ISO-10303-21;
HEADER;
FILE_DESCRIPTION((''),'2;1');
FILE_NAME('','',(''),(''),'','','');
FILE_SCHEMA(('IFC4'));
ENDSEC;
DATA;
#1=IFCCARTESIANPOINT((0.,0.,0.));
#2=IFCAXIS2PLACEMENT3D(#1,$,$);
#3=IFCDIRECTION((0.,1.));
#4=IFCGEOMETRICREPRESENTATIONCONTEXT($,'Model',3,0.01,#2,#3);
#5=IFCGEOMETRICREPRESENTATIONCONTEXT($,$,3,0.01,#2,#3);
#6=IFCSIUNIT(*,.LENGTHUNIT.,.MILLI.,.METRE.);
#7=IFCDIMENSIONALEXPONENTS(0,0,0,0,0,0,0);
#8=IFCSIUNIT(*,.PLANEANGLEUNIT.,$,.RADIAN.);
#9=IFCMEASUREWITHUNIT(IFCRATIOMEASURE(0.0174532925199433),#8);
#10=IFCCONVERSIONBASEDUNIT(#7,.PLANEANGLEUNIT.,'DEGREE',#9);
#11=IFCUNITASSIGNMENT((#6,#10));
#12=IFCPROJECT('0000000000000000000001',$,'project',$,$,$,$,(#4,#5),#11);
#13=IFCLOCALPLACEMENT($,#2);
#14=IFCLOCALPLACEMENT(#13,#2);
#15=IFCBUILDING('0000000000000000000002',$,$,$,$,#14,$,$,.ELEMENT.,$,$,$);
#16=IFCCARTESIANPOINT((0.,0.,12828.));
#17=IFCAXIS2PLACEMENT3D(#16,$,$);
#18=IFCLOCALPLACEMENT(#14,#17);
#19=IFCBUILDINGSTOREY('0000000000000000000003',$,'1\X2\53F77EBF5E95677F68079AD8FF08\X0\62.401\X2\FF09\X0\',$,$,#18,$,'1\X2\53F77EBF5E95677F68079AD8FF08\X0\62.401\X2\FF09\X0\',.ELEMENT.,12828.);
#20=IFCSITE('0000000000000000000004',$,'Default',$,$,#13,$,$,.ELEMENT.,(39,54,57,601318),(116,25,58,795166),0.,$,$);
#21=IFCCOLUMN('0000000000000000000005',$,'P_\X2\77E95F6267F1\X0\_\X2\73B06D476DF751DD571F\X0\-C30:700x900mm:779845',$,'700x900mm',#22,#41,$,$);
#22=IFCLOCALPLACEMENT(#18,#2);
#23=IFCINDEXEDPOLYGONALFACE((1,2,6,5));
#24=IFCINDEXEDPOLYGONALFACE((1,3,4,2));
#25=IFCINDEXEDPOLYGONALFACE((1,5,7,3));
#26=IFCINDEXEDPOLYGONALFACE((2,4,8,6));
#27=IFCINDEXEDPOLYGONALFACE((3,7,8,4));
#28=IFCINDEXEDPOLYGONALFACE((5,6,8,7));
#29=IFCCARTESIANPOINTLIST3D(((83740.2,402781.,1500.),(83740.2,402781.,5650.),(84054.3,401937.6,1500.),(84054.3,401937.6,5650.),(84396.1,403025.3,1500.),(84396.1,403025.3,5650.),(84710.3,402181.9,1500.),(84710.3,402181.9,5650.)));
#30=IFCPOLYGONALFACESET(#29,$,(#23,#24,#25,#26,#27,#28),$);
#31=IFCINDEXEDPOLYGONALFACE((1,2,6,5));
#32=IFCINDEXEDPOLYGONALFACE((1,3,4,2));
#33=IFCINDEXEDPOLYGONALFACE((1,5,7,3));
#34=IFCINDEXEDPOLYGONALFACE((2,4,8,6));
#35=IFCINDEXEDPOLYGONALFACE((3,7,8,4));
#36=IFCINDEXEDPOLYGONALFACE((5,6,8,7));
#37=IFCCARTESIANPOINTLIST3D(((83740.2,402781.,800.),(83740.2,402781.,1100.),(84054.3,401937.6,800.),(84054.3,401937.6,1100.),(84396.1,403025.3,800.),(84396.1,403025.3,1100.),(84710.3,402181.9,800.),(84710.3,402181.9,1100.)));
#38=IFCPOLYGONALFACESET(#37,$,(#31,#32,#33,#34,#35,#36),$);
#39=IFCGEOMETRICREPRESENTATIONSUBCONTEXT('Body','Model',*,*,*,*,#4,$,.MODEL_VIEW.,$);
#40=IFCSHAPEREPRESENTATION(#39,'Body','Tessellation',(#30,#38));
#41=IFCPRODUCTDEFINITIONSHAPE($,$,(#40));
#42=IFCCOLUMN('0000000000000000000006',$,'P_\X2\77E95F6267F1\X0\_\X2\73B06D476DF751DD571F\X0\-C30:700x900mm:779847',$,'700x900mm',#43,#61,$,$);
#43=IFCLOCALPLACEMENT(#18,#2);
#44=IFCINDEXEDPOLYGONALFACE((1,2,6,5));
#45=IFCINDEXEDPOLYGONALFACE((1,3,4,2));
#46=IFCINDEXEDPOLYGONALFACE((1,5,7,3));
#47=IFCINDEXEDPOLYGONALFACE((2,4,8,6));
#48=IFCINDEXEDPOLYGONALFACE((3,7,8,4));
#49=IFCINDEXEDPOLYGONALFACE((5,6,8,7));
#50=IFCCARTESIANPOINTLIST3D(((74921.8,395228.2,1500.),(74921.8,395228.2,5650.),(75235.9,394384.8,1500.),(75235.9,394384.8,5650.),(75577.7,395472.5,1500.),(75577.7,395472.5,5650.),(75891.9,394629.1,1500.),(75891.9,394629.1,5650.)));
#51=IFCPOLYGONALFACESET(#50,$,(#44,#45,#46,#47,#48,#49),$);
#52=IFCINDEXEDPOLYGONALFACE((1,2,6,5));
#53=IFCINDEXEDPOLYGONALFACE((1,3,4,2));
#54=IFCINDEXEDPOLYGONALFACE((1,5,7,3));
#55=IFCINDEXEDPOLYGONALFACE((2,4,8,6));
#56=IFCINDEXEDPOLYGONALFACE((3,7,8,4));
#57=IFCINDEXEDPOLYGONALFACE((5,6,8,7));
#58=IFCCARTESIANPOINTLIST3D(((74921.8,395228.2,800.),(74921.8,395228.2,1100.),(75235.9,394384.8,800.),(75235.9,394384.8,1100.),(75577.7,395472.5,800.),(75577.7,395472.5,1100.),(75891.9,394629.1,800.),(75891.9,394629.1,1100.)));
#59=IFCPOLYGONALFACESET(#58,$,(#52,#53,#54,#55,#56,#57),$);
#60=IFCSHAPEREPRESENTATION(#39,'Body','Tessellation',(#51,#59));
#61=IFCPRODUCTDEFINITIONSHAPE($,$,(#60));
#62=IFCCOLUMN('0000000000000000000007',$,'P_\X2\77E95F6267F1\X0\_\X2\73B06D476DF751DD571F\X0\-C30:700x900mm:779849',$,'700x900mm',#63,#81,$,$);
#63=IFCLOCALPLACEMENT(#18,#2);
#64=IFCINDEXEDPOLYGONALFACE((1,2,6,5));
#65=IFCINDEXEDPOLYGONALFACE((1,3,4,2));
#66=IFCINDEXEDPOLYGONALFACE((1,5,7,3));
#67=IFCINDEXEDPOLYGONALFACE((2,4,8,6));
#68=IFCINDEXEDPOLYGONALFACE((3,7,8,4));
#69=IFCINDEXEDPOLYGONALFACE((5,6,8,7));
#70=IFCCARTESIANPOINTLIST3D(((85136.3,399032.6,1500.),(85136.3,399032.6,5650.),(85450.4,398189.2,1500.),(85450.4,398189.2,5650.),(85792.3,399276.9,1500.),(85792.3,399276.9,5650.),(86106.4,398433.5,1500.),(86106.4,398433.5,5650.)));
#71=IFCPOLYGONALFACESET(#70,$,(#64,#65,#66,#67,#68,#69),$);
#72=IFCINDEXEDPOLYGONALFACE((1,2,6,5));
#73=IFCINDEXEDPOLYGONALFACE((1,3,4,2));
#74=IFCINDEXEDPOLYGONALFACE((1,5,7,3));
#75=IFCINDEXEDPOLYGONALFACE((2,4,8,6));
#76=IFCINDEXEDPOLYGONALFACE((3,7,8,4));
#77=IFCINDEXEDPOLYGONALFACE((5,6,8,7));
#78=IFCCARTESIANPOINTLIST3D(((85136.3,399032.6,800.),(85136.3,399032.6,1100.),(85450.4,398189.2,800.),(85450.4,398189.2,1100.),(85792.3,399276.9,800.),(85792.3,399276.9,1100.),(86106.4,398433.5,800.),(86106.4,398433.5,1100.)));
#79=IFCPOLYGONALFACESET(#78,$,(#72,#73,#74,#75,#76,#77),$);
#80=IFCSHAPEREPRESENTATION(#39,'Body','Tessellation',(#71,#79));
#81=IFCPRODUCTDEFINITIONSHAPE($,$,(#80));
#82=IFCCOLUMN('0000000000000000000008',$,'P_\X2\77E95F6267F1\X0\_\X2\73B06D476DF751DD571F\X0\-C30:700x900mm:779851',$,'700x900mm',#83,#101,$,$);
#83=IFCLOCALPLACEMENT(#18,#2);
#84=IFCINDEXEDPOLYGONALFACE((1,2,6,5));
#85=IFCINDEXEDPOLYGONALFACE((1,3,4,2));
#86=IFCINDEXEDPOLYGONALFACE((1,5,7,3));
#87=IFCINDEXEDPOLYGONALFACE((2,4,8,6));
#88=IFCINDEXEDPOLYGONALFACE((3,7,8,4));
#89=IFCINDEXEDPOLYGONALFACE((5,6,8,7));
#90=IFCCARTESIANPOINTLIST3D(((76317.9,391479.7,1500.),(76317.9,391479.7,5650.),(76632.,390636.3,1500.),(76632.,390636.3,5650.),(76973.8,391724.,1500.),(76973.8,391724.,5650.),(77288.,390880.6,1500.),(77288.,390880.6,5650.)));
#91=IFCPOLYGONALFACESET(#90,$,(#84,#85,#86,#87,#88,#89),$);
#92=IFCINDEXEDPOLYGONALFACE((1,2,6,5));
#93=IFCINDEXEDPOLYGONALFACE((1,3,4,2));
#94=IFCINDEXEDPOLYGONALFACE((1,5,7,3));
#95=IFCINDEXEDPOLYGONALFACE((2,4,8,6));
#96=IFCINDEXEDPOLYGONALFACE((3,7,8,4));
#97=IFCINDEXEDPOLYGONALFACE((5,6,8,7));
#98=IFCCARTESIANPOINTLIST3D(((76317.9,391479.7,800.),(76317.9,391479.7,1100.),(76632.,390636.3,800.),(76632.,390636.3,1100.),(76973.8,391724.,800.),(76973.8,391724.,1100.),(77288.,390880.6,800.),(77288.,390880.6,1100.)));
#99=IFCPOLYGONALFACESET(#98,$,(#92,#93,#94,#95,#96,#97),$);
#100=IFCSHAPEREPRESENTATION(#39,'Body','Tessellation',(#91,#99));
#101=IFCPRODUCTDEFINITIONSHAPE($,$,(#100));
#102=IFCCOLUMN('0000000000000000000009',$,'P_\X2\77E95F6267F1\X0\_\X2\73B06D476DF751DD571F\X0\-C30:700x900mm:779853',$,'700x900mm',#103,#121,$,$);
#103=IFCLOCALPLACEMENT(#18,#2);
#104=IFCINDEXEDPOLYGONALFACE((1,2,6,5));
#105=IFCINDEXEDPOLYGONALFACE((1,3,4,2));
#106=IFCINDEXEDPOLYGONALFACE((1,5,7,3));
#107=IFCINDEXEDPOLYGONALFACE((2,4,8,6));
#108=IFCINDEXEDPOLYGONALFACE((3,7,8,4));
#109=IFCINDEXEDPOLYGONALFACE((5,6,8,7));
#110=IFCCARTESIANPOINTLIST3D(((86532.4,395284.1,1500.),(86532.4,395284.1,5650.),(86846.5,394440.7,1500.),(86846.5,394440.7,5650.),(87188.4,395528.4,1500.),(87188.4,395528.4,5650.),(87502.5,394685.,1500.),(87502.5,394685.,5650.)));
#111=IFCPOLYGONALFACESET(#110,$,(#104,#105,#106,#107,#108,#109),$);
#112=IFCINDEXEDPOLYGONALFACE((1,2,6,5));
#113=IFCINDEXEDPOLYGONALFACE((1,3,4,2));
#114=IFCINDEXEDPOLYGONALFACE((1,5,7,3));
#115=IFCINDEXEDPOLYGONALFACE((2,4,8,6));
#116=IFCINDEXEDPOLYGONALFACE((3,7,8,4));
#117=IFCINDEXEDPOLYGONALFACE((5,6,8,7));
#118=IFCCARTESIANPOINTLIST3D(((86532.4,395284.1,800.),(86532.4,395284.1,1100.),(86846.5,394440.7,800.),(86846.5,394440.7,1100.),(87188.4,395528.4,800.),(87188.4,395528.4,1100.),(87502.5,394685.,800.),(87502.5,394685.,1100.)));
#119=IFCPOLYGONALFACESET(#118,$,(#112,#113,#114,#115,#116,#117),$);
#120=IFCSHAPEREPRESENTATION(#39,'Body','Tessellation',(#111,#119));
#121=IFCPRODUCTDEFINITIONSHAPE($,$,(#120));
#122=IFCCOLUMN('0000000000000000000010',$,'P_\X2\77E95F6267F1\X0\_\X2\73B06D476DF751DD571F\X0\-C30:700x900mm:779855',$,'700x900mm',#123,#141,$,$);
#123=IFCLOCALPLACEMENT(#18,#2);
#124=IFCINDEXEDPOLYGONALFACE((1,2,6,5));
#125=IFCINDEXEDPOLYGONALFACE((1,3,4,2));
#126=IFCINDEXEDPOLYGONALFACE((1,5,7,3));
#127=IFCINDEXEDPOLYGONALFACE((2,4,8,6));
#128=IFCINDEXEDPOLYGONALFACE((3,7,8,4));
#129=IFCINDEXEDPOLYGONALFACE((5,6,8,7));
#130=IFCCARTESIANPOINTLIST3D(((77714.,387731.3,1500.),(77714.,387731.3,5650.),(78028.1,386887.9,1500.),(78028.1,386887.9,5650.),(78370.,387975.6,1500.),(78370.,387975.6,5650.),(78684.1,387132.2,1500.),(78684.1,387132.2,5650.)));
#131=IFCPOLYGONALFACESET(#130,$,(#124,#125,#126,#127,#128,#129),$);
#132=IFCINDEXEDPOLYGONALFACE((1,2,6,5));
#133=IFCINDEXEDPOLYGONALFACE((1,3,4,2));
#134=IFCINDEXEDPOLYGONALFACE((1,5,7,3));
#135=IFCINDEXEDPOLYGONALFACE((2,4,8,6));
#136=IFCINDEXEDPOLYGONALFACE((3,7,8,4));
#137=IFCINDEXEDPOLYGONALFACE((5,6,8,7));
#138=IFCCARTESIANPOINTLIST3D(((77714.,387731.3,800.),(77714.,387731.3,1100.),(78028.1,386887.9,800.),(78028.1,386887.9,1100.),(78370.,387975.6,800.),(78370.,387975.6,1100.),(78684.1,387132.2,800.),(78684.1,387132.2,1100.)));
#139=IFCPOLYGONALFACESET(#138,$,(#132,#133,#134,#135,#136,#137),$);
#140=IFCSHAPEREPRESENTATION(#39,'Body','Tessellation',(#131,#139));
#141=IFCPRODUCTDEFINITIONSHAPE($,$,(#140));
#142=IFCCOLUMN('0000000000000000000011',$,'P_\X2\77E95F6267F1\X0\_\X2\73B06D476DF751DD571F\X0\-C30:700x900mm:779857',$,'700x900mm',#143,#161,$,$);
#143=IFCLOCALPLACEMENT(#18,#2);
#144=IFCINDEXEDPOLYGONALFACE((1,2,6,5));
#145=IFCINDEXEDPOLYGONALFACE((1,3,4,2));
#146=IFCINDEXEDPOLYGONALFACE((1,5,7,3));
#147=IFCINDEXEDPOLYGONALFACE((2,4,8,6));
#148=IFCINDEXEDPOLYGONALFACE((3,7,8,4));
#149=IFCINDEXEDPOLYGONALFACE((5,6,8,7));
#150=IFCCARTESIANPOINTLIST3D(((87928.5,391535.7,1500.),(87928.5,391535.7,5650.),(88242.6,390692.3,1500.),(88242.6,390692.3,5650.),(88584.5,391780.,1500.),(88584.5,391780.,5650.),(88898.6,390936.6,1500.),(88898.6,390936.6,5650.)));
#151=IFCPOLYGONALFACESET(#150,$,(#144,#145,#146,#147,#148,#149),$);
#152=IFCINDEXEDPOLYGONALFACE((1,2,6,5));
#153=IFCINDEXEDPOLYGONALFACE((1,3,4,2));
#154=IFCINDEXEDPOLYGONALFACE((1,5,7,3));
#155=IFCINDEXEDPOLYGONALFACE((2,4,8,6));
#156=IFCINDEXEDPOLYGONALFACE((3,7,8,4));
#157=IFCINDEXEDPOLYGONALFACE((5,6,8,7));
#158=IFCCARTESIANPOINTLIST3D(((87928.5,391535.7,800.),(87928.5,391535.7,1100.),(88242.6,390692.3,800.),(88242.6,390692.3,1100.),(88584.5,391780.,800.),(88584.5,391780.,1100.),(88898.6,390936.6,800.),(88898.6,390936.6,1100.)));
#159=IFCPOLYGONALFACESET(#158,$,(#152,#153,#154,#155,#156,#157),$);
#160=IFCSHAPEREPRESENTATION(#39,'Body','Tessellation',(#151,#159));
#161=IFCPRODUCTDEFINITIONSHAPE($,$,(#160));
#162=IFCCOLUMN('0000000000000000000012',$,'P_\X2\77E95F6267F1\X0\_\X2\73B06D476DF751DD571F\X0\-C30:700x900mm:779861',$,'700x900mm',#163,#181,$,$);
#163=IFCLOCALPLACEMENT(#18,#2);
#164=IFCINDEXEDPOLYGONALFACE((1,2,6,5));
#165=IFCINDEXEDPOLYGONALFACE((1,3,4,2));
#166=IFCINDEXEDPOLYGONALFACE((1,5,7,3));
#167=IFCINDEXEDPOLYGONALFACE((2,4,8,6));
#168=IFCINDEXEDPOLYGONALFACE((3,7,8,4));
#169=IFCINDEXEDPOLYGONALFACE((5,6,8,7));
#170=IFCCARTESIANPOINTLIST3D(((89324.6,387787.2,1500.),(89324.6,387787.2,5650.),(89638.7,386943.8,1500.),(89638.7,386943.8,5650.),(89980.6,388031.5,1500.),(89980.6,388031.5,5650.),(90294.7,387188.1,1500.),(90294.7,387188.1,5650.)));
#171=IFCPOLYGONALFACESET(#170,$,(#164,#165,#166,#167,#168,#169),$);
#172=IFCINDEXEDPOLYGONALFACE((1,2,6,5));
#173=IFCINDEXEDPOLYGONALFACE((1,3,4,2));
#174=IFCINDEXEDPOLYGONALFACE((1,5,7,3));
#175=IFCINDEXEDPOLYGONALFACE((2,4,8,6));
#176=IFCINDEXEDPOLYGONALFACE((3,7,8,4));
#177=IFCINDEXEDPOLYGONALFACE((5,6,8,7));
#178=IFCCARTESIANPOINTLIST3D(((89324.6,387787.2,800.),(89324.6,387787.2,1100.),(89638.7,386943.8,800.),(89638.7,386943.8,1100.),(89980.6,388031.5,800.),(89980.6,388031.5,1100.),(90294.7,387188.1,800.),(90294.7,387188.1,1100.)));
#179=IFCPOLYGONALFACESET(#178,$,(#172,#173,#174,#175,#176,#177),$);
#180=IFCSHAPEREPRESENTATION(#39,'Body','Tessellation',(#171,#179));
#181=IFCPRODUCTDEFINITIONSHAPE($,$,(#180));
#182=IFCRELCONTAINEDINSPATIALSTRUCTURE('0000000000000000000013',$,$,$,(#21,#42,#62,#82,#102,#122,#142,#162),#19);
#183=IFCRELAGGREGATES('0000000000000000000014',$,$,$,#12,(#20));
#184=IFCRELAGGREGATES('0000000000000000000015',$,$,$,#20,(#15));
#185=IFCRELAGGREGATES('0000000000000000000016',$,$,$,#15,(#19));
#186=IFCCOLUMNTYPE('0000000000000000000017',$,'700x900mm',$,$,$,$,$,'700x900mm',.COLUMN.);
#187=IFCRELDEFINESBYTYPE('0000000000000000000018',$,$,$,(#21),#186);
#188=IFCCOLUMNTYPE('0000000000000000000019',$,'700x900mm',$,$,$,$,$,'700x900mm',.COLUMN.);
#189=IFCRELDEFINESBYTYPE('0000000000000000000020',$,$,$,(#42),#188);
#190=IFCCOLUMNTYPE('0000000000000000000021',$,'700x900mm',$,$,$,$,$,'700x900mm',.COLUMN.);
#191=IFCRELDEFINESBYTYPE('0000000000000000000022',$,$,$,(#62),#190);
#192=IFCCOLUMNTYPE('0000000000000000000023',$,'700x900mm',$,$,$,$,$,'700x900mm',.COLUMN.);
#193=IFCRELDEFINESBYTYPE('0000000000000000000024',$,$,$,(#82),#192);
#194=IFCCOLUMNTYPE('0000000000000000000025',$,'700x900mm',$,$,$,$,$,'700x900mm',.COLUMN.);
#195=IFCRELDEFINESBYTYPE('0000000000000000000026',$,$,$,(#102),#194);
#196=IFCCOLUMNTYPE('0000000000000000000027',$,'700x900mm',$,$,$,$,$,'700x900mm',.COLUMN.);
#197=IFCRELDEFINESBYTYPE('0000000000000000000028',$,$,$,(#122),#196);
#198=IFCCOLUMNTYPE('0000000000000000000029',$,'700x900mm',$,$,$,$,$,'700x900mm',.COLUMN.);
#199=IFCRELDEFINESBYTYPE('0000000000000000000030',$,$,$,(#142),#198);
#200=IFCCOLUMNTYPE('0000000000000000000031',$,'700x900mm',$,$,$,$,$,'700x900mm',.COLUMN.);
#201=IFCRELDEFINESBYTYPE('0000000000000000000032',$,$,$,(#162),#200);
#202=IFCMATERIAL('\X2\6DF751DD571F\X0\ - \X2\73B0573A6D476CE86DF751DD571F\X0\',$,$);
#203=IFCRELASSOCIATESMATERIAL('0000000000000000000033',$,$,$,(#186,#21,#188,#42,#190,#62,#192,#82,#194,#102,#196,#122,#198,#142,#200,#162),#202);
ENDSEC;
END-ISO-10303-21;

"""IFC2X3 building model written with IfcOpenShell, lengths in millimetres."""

from ifc_helpers import new_model, entity, si_unit, converted_unit, direction, frame, frame_2d, origin, origin_2d_with_axis, place, context, subcontext, project, spatial, rectangle, extrude, source, transform, mapped, material, type_object, type_shapes, element, save


model = new_model("IFC2X3")

# Units and contexts
model_context = context("Model", 3, precision=0.01, world=origin(), true_north=direction((0.0, 1.0)))
context_of_model = context(None, 3, precision=0.01, world=origin(), true_north=direction((0.0, 1.0)))
body_context = subcontext(model_context, "Body", "Model", "MODEL_VIEW")
ifc_project = project(units=[si_unit("LENGTHUNIT", "METRE", prefix="MILLI"), converted_unit("PLANEANGLEUNIT", "DEGREE", entity("IfcRatioMeasure", 0.0174532925199433), si_unit("PLANEANGLEUNIT", "RADIAN"), dimensions=[0, 0, 0, 0, 0, 0, 0])], contexts=[model_context, context_of_model])

# Site, building, storey
site_placement = place(None, origin())
site = spatial("IfcSite", under=ifc_project, at=site_placement, Name="Default", CompositionType="ELEMENT", RefLatitude=(39, 54, 57, 601318), RefLongitude=(116, 25, 58, 795166), RefElevation=0.0)
building_placement = place(site_placement, origin())
building = spatial("IfcBuilding", under=site, at=building_placement, CompositionType="ELEMENT")
storey_placement = place(building_placement, frame((0.0, 0.0, 12828.0)))
storey = spatial("IfcBuildingStorey", under=building, at=storey_placement, Name="1号线底板标高（62.401）", LongName="1号线底板标高（62.401）", CompositionType="ELEMENT", Elevation=12828.0)

# Columns
ifc_material_1 = material(Name="混凝土 - 现场浇注混凝土")
column_type_1 = type_object("IfcColumnType", Name="700x900mm", ElementType="700x900mm", PredefinedType="COLUMN", material=ifc_material_1)
shared_shape_1 = source(origin(), body_context, "Body", "SweptSolid", [
    extrude(rectangle(XDim=700.0, YDim=900.0, at=frame_2d((0.0, 0.0), x_axis=(1.0, 0.0))), frame((485.1, 543.9, 700.0), z_axis=(0.0, 0.0, 1.0), x_axis=(-0.937112, -0.349028, 0.0)), (0.0, 0.0, 1.0), 4150.0),
    extrude(rectangle(XDim=700.0, YDim=900.0, at=frame_2d((0.0, 0.0), x_axis=(1.0, 0.0))), frame((485.1, 543.9, 0.0), z_axis=(0.0, 0.0, 1.0), x_axis=(-0.937112, -0.349028, 0.0)), (0.0, 0.0, 1.0), 300.0),
])
type_shapes(column_type_1, [shared_shape_1])
column_1_placement = place(storey_placement, frame((83740.2, 401937.6, 800.0)))
element("IfcColumn", 1, at=column_1_placement, inside=storey, type_object=column_type_1, material=ifc_material_1, Name="P_矩形柱_现浇混凝土-C30:700x900mm:779845", ObjectType="700x900mm", context=body_context, shape_type="MappedRepresentation", body=[
    mapped(shared_shape_1, transform((0.0, 0.0, 0.0), scale=1.0)),
])
column_type_2 = type_object("IfcColumnType", Name="700x900mm", ElementType="700x900mm", PredefinedType="COLUMN", material=ifc_material_1)
shared_shape_2 = source(origin(), body_context, "Body", "SweptSolid", [
    extrude(rectangle(XDim=700.0, YDim=900.0, at=frame_2d((0.0, 0.0), x_axis=(1.0, 0.0))), frame((485.1, 543.9, 700.0), z_axis=(0.0, 0.0, 1.0), x_axis=(-0.937112, -0.349028, 0.0)), (0.0, 0.0, 1.0), 4150.0),
    extrude(rectangle(XDim=700.0, YDim=900.0, at=frame_2d((0.0, 0.0), x_axis=(1.0, 0.0))), frame((485.1, 543.9, 0.0), z_axis=(0.0, 0.0, 1.0), x_axis=(-0.937112, -0.349028, 0.0)), (0.0, 0.0, 1.0), 300.0),
])
type_shapes(column_type_2, [shared_shape_2])
column_2_placement = place(storey_placement, frame((74921.8, 394384.8, 800.0)))
element("IfcColumn", 2, at=column_2_placement, inside=storey, type_object=column_type_2, material=ifc_material_1, Name="P_矩形柱_现浇混凝土-C30:700x900mm:779847", ObjectType="700x900mm", context=body_context, shape_type="MappedRepresentation", body=[
    mapped(shared_shape_2, transform((0.0, 0.0, 0.0), scale=1.0)),
])
column_type_3 = type_object("IfcColumnType", Name="700x900mm", ElementType="700x900mm", PredefinedType="COLUMN", material=ifc_material_1)
shared_shape_3 = source(origin(), body_context, "Body", "SweptSolid", [
    extrude(rectangle(XDim=700.0, YDim=900.0, at=origin_2d_with_axis()), frame((485.1, 543.9, 700.0), z_axis=(0.0, 0.0, 1.0), x_axis=(-0.937112, -0.349028, 0.0)), (0.0, 0.0, 1.0), 4150.0),
    extrude(rectangle(XDim=700.0, YDim=900.0, at=origin_2d_with_axis()), frame((485.1, 543.9, 0.0), z_axis=(0.0, 0.0, 1.0), x_axis=(-0.937112, -0.349028, 0.0)), (0.0, 0.0, 1.0), 300.0),
])
type_shapes(column_type_3, [shared_shape_3])
column_3_placement = place(storey_placement, frame((85136.3, 398189.2, 800.0)))
element("IfcColumn", 3, at=column_3_placement, inside=storey, type_object=column_type_3, material=ifc_material_1, Name="P_矩形柱_现浇混凝土-C30:700x900mm:779849", ObjectType="700x900mm", context=body_context, shape_type="MappedRepresentation", body=[
    mapped(shared_shape_3, transform((0.0, 0.0, 0.0), scale=1.0)),
])
column_type_4 = type_object("IfcColumnType", Name="700x900mm", ElementType="700x900mm", PredefinedType="COLUMN", material=ifc_material_1)
shared_shape_4 = source(origin(), body_context, "Body", "SweptSolid", [
    extrude(rectangle(XDim=700.0, YDim=900.0, at=frame_2d((0.0, 0.0), x_axis=(1.0, 0.0))), frame((485.1, 543.9, 700.0), z_axis=(0.0, 0.0, 1.0), x_axis=(-0.937112, -0.349028, 0.0)), (0.0, 0.0, 1.0), 4150.0),
    extrude(rectangle(XDim=700.0, YDim=900.0, at=frame_2d((0.0, 0.0), x_axis=(1.0, 0.0))), frame((485.1, 543.9, 0.0), z_axis=(0.0, 0.0, 1.0), x_axis=(-0.937112, -0.349028, 0.0)), (0.0, 0.0, 1.0), 300.0),
])
type_shapes(column_type_4, [shared_shape_4])
column_4_placement = place(storey_placement, frame((76317.9, 390636.3, 800.0)))
element("IfcColumn", 4, at=column_4_placement, inside=storey, type_object=column_type_4, material=ifc_material_1, Name="P_矩形柱_现浇混凝土-C30:700x900mm:779851", ObjectType="700x900mm", context=body_context, shape_type="MappedRepresentation", body=[
    mapped(shared_shape_4, transform((0.0, 0.0, 0.0), scale=1.0)),
])
column_type_5 = type_object("IfcColumnType", Name="700x900mm", ElementType="700x900mm", PredefinedType="COLUMN", material=ifc_material_1)
shared_shape_5 = source(origin(), body_context, "Body", "SweptSolid", [
    extrude(rectangle(XDim=700.0, YDim=900.0, at=frame_2d((0.0, 0.0), x_axis=(1.0, 0.0))), frame((485.1, 543.9, 700.0), z_axis=(0.0, 0.0, 1.0), x_axis=(-0.937112, -0.349028, 0.0)), (0.0, 0.0, 1.0), 4150.0),
    extrude(rectangle(XDim=700.0, YDim=900.0, at=frame_2d((0.0, 0.0), x_axis=(1.0, 0.0))), frame((485.1, 543.9, 0.0), z_axis=(0.0, 0.0, 1.0), x_axis=(-0.937112, -0.349028, 0.0)), (0.0, 0.0, 1.0), 300.0),
])
type_shapes(column_type_5, [shared_shape_5])
column_5_placement = place(storey_placement, frame((86532.4, 394440.7, 800.0)))
element("IfcColumn", 5, at=column_5_placement, inside=storey, type_object=column_type_5, material=ifc_material_1, Name="P_矩形柱_现浇混凝土-C30:700x900mm:779853", ObjectType="700x900mm", context=body_context, shape_type="MappedRepresentation", body=[
    mapped(shared_shape_5, transform((0.0, 0.0, 0.0), scale=1.0)),
])
column_type_6 = type_object("IfcColumnType", Name="700x900mm", ElementType="700x900mm", PredefinedType="COLUMN", material=ifc_material_1)
shared_shape_6 = source(origin(), body_context, "Body", "SweptSolid", [
    extrude(rectangle(XDim=700.0, YDim=900.0, at=frame_2d((0.0, 0.0), x_axis=(1.0, 0.0))), frame((485.1, 543.9, 700.0), z_axis=(0.0, 0.0, 1.0), x_axis=(-0.937112, -0.349028, 0.0)), (0.0, 0.0, 1.0), 4150.0),
    extrude(rectangle(XDim=700.0, YDim=900.0, at=frame_2d((0.0, 0.0), x_axis=(1.0, 0.0))), frame((485.1, 543.9, 0.0), z_axis=(0.0, 0.0, 1.0), x_axis=(-0.937112, -0.349028, 0.0)), (0.0, 0.0, 1.0), 300.0),
])
type_shapes(column_type_6, [shared_shape_6])
column_6_placement = place(storey_placement, frame((77714.0, 386887.9, 800.0)))
element("IfcColumn", 6, at=column_6_placement, inside=storey, type_object=column_type_6, material=ifc_material_1, Name="P_矩形柱_现浇混凝土-C30:700x900mm:779855", ObjectType="700x900mm", context=body_context, shape_type="MappedRepresentation", body=[
    mapped(shared_shape_6, transform((0.0, 0.0, 0.0), scale=1.0)),
])
column_type_7 = type_object("IfcColumnType", Name="700x900mm", ElementType="700x900mm", PredefinedType="COLUMN", material=ifc_material_1)
shared_shape_7 = source(origin(), body_context, "Body", "SweptSolid", [
    extrude(rectangle(XDim=700.0, YDim=900.0, at=origin_2d_with_axis()), frame((485.1, 543.9, 700.0), z_axis=(0.0, 0.0, 1.0), x_axis=(-0.937112, -0.349028, 0.0)), (0.0, 0.0, 1.0), 4150.0),
    extrude(rectangle(XDim=700.0, YDim=900.0, at=origin_2d_with_axis()), frame((485.1, 543.9, 0.0), z_axis=(0.0, 0.0, 1.0), x_axis=(-0.937112, -0.349028, 0.0)), (0.0, 0.0, 1.0), 300.0),
])
type_shapes(column_type_7, [shared_shape_7])
column_7_placement = place(storey_placement, frame((87928.5, 390692.3, 800.0)))
element("IfcColumn", 7, at=column_7_placement, inside=storey, type_object=column_type_7, material=ifc_material_1, Name="P_矩形柱_现浇混凝土-C30:700x900mm:779857", ObjectType="700x900mm", context=body_context, shape_type="MappedRepresentation", body=[
    mapped(shared_shape_7, transform((0.0, 0.0, 0.0), scale=1.0)),
])
column_type_8 = type_object("IfcColumnType", Name="700x900mm", ElementType="700x900mm", PredefinedType="COLUMN", material=ifc_material_1)
shared_shape_8 = source(origin(), body_context, "Body", "SweptSolid", [
    extrude(rectangle(XDim=700.0, YDim=900.0, at=frame_2d((0.0, 0.0), x_axis=(1.0, 0.0))), frame((485.1, 543.9, 700.0), z_axis=(0.0, 0.0, 1.0), x_axis=(-0.937112, -0.349028, 0.0)), (0.0, 0.0, 1.0), 4150.0),
    extrude(rectangle(XDim=700.0, YDim=900.0, at=frame_2d((0.0, 0.0), x_axis=(1.0, 0.0))), frame((485.1, 543.9, 0.0), z_axis=(0.0, 0.0, 1.0), x_axis=(-0.937112, -0.349028, 0.0)), (0.0, 0.0, 1.0), 300.0),
])
type_shapes(column_type_8, [shared_shape_8])
column_8_placement = place(storey_placement, frame((89324.6, 386943.8, 800.0)))
element("IfcColumn", 8, at=column_8_placement, inside=storey, type_object=column_type_8, material=ifc_material_1, Name="P_矩形柱_现浇混凝土-C30:700x900mm:779861", ObjectType="700x900mm", context=body_context, shape_type="MappedRepresentation", body=[
    mapped(shared_shape_8, transform((0.0, 0.0, 0.0), scale=1.0)),
])

save(model, "model.ifc")
